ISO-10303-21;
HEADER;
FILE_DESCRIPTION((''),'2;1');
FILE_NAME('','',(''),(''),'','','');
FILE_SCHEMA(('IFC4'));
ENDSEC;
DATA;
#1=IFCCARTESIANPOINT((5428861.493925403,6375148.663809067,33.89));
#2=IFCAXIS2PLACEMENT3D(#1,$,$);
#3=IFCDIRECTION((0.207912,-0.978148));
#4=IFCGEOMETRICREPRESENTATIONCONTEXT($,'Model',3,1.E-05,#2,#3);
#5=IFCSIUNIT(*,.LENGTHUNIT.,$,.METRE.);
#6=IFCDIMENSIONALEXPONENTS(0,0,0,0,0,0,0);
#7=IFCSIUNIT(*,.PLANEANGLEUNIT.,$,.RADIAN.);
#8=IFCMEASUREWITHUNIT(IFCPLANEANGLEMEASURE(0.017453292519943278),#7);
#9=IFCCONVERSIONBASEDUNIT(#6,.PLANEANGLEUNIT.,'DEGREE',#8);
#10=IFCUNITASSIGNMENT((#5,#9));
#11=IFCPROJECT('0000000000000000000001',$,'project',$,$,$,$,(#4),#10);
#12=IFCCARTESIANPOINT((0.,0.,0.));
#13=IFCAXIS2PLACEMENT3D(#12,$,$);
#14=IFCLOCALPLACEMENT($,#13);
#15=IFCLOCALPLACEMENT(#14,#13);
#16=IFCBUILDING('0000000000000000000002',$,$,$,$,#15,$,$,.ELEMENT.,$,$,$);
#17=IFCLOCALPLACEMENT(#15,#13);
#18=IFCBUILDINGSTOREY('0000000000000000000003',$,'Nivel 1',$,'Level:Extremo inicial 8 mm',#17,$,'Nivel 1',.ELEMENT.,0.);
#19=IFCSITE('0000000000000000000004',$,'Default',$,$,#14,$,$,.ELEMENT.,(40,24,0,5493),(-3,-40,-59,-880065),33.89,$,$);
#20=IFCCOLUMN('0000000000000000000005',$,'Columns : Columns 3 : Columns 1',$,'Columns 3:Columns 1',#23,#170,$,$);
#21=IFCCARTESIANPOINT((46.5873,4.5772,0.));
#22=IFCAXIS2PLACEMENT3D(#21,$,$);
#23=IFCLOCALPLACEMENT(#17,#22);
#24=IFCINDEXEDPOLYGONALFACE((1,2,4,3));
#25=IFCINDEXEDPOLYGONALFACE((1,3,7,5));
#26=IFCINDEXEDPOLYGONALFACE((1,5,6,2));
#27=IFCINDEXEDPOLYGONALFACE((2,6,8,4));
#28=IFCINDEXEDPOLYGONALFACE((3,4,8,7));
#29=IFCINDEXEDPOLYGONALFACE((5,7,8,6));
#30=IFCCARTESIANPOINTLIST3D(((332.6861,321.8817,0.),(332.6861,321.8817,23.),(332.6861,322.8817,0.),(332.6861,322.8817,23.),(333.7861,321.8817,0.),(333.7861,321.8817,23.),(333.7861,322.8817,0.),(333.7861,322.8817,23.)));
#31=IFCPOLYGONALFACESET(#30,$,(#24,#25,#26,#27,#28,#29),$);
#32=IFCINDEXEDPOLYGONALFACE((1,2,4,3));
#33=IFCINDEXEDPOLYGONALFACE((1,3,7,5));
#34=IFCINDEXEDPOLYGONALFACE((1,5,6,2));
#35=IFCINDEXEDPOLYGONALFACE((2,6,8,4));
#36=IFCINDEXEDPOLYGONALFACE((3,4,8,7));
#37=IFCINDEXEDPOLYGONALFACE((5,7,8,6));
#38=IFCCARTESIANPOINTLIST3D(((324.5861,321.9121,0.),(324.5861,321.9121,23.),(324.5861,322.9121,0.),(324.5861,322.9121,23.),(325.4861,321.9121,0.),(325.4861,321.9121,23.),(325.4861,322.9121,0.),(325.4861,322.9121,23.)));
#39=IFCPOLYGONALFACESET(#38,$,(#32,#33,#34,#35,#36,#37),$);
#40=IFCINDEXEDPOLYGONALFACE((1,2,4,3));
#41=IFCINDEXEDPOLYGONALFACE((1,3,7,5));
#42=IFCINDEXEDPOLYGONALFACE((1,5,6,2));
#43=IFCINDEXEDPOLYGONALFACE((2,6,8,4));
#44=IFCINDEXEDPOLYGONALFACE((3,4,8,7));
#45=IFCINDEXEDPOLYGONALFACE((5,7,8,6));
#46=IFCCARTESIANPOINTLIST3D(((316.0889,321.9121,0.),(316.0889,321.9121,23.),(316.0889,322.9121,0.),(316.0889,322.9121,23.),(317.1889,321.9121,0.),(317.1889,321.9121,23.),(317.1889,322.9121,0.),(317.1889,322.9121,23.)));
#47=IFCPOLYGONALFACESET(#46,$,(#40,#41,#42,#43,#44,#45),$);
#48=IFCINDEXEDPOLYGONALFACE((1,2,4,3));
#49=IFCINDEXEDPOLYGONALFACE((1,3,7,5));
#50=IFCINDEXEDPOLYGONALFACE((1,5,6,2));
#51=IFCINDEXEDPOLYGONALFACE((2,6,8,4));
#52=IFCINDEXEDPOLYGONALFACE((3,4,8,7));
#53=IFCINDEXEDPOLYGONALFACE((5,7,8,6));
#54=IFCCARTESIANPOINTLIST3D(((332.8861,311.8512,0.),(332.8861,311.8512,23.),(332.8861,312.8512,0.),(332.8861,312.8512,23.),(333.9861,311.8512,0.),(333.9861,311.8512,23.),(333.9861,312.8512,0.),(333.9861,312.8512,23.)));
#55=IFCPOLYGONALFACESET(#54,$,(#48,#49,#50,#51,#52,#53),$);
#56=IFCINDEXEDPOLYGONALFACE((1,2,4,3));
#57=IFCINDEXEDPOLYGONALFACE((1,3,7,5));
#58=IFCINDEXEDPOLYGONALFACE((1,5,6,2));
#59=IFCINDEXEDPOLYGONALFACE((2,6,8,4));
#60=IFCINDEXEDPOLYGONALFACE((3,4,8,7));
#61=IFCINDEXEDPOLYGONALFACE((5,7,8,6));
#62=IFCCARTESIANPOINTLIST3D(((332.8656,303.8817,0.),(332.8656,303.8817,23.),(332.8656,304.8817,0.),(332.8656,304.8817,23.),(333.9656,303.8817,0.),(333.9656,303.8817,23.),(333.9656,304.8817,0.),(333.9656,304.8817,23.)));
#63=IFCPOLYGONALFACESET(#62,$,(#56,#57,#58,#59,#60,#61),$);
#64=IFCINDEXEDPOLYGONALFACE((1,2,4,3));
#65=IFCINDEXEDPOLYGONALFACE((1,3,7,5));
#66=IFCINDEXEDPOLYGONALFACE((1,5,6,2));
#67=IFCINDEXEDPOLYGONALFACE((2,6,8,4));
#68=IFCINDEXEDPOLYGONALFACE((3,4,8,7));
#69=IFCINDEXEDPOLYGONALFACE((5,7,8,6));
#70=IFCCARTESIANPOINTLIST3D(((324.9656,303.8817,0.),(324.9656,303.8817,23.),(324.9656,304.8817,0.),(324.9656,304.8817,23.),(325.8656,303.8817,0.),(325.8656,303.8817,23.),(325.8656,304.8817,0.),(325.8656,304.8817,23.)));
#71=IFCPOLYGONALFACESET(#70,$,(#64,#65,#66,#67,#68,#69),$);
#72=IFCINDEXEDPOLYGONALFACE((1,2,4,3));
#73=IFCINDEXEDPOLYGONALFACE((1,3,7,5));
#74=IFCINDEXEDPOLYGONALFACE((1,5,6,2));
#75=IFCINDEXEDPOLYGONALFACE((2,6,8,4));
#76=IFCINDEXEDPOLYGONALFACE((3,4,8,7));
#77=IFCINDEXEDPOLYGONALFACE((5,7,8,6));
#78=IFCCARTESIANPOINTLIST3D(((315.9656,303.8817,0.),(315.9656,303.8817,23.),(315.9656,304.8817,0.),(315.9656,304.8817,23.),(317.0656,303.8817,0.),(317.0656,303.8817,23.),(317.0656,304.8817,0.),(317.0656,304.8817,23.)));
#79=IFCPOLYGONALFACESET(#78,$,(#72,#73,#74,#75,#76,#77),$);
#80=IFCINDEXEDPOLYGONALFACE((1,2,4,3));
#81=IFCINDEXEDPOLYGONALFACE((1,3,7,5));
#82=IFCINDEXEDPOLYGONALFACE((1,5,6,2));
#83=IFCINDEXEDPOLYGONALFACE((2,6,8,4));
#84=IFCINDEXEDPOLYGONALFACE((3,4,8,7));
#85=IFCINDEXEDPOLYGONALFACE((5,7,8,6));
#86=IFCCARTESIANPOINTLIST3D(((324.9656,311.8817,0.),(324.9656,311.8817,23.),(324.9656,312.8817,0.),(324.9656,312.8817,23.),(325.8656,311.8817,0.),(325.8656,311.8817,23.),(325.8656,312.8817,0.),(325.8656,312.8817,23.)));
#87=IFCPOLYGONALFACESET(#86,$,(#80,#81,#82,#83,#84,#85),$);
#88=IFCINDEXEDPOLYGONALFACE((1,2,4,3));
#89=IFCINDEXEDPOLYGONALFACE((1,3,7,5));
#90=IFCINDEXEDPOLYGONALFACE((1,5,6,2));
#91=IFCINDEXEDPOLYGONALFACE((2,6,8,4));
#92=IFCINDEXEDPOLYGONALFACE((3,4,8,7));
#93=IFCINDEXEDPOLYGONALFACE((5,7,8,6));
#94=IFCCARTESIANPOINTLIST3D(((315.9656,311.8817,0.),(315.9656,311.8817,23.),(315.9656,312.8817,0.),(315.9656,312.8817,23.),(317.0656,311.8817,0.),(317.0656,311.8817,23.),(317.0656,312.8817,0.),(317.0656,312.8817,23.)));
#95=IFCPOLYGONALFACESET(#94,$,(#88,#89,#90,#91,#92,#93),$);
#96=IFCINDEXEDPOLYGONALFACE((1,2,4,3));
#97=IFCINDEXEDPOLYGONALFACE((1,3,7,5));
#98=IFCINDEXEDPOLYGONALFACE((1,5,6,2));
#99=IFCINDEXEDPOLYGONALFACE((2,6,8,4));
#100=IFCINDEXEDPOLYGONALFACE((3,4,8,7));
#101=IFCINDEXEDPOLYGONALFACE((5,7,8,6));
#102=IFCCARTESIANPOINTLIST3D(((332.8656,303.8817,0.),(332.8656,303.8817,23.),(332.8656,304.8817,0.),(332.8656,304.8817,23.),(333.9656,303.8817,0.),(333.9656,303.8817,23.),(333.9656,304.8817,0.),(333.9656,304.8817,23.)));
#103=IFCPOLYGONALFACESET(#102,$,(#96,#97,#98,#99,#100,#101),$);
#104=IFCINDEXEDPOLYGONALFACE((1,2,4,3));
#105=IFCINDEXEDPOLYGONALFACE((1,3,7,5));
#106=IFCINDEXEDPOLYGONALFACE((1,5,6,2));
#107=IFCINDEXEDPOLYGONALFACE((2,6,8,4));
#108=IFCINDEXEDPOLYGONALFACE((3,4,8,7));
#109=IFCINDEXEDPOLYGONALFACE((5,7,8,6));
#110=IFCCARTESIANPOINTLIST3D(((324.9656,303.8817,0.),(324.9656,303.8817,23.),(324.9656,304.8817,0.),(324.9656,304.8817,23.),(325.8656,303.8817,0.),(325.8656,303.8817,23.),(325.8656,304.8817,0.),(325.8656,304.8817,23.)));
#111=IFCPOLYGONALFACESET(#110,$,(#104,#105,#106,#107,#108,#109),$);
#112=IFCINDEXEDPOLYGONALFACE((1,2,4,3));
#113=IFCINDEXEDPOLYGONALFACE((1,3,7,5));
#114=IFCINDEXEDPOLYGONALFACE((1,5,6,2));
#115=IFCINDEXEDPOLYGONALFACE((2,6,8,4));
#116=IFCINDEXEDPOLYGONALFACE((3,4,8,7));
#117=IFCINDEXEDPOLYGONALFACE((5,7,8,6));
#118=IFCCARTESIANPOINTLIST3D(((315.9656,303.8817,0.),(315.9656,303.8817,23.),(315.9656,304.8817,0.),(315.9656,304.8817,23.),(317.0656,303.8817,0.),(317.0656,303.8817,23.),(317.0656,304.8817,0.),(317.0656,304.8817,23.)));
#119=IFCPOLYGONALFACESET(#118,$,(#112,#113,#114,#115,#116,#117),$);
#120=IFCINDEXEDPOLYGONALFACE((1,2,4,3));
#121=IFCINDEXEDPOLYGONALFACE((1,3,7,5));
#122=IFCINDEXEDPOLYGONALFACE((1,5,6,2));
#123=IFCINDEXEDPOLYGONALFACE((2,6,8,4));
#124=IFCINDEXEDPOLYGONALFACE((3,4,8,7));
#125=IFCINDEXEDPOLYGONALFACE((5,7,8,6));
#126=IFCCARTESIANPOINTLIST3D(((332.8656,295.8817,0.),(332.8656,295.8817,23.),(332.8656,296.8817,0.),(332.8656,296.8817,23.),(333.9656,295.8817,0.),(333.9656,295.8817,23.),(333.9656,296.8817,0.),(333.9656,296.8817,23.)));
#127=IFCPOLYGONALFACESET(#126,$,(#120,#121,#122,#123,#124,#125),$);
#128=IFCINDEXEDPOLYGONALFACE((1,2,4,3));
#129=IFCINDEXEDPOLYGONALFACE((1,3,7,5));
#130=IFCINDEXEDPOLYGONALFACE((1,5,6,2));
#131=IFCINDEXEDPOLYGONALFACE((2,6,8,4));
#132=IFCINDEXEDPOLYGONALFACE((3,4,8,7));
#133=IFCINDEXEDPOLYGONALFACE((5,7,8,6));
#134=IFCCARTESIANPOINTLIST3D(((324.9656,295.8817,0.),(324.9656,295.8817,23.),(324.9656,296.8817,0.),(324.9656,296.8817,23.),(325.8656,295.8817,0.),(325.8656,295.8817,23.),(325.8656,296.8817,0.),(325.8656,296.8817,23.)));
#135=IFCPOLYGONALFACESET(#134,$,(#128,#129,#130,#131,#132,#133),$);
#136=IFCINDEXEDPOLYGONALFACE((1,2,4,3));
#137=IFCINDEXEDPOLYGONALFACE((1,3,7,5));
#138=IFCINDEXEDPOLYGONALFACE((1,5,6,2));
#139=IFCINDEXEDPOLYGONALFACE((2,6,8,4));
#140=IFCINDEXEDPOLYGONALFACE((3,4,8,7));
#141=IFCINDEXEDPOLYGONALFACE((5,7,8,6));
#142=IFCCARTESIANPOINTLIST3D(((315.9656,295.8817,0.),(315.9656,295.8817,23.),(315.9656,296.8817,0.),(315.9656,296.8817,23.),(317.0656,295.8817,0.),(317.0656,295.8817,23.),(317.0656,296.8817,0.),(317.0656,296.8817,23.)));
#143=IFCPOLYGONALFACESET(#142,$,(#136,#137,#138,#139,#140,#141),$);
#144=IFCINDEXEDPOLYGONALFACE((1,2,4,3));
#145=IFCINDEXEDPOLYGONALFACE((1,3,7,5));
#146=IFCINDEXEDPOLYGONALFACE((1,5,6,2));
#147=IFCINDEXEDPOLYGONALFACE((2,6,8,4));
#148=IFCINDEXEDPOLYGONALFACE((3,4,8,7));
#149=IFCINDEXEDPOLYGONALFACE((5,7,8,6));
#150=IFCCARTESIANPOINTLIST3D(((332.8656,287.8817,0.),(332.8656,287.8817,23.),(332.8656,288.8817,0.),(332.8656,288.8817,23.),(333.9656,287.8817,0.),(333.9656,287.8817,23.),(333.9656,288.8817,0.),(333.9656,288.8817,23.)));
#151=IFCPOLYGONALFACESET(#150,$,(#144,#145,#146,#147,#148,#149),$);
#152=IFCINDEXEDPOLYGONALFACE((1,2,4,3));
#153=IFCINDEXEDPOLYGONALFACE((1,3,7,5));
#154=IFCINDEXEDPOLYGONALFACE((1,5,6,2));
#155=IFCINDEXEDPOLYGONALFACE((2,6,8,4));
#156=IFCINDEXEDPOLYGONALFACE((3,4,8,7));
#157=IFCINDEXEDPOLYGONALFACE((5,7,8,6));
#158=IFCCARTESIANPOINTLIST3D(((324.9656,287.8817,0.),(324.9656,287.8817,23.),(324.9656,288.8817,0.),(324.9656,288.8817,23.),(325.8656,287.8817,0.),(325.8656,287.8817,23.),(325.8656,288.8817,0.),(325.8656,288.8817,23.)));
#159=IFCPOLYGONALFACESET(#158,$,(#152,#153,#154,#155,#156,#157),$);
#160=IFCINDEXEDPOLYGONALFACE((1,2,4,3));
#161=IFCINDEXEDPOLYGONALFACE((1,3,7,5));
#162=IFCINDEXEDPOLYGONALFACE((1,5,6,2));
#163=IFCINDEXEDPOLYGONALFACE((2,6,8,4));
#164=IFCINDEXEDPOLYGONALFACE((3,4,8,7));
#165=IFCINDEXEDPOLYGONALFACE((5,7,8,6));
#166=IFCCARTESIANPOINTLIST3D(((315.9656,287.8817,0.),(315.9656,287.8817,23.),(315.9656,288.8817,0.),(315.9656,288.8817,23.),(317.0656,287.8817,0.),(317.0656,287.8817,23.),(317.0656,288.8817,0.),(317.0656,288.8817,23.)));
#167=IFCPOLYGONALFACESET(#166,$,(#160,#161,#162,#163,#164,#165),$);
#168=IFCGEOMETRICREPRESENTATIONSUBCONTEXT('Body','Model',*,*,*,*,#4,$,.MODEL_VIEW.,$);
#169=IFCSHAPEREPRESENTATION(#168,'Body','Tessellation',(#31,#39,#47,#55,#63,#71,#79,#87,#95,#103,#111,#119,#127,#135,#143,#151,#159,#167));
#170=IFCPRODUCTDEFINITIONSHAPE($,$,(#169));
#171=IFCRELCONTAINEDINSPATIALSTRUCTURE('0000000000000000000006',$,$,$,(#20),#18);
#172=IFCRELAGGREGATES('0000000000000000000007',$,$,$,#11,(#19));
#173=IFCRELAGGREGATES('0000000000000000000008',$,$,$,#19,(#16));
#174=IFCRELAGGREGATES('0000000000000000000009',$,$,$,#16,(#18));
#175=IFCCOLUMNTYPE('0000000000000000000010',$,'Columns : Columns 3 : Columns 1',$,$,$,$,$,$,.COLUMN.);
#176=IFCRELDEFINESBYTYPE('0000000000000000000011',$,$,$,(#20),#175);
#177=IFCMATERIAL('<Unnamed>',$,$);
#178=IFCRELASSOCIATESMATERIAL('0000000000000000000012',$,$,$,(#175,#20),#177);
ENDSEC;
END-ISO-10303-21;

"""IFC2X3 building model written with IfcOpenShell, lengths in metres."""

from ifc_helpers import new_model, entity, si_unit, converted_unit, direction, frame, frame_2d, origin, place, context, subcontext, project, spatial, rectangle, extrude, source, transform, mapped, material, type_object, type_shapes, element, save


model = new_model("IFC2X3")

# Units and contexts
model_context = context("Model", 3, precision=1e-05, world=frame((5428861.493925403, 6375148.663809067, 33.89)), true_north=direction((0.207912, -0.978148)))
body_context = subcontext(model_context, "Body", "Model", "MODEL_VIEW")
ifc_project = project(units=[si_unit("LENGTHUNIT", "METRE"), converted_unit("PLANEANGLEUNIT", "DEGREE", entity("IfcPlaneAngleMeasure", 0.017453292519943278), si_unit("PLANEANGLEUNIT", "RADIAN"), dimensions=[0, 0, 0, 0, 0, 0, 0])], contexts=[model_context])

# Site, building, storey
site_placement = place(None, origin())
site = spatial("IfcSite", under=ifc_project, at=site_placement, Name="Default", CompositionType="ELEMENT", RefLatitude=(40, 24, 0, 5493), RefLongitude=(-3, -40, -59, -880065), RefElevation=33.89)
building_placement = place(site_placement, origin())
building = spatial("IfcBuilding", under=site, at=building_placement, CompositionType="ELEMENT")
storey_placement = place(building_placement, origin())
storey = spatial("IfcBuildingStorey", under=building, at=storey_placement, Name="Nivel 1", ObjectType="Level:Extremo inicial 8 mm", LongName="Nivel 1", CompositionType="ELEMENT", Elevation=0.0)

# Column
ifc_material_1 = material(Name="<Unnamed>")
column_type = type_object("IfcColumnType", Name="Columns : Columns 3 : Columns 1", PredefinedType="COLUMN", material=ifc_material_1)
shared_shape = source(origin(), body_context, "Body", "SweptSolid", [
    extrude(rectangle(XDim=1.0, YDim=1.1, at=frame_2d((0.0, 0.0), x_axis=(1.0, 0.0))), frame((333.2361, 322.3817, 0.0), z_axis=(0.0, 0.0, 1.0), x_axis=(0.0, 1.0, 0.0)), (0.0, 0.0, 1.0), 23.0),
    extrude(rectangle(XDim=0.9, YDim=1.0, at=frame_2d((0.0, 0.0), x_axis=(1.0, 0.0))), frame((325.0361, 322.4121, 0.0)), (0.0, 0.0, 1.0), 23.0),
    extrude(rectangle(XDim=1.1, YDim=1.0, at=frame_2d((0.0, 0.0), x_axis=(1.0, 0.0))), frame((316.6389, 322.4121, 0.0)), (0.0, 0.0, 1.0), 23.0),
    extrude(rectangle(XDim=1.0, YDim=1.1, at=frame_2d((0.0, 0.0), x_axis=(1.0, 0.0))), frame((333.4361, 312.3512, 0.0), z_axis=(0.0, 0.0, 1.0), x_axis=(0.0, 1.0, 0.0)), (0.0, 0.0, 1.0), 23.0),
    extrude(rectangle(XDim=1.0, YDim=1.1, at=frame_2d((0.0, 0.0), x_axis=(1.0, 0.0))), frame((333.4156, 304.3817, 0.0), z_axis=(0.0, 0.0, 1.0), x_axis=(0.0, 1.0, 0.0)), (0.0, 0.0, 1.0), 23.0),
    extrude(rectangle(XDim=0.9, YDim=1.0, at=frame_2d((0.0, 0.0), x_axis=(1.0, 0.0))), frame((325.4156, 304.3817, 0.0)), (0.0, 0.0, 1.0), 23.0),
    extrude(rectangle(XDim=1.1, YDim=1.0, at=frame_2d((0.0, 0.0), x_axis=(1.0, 0.0))), frame((316.5156, 304.3817, 0.0)), (0.0, 0.0, 1.0), 23.0),
    extrude(rectangle(XDim=0.9, YDim=1.0, at=frame_2d((0.0, 0.0), x_axis=(1.0, 0.0))), frame((325.4156, 312.3817, 0.0)), (0.0, 0.0, 1.0), 23.0),
    extrude(rectangle(XDim=1.1, YDim=1.0, at=frame_2d((0.0, 0.0), x_axis=(1.0, 0.0))), frame((316.5156, 312.3817, 0.0)), (0.0, 0.0, 1.0), 23.0),
    extrude(rectangle(XDim=1.0, YDim=1.1, at=frame_2d((0.0, 0.0), x_axis=(1.0, 0.0))), frame((333.4156, 304.3817, 0.0), z_axis=(0.0, 0.0, 1.0), x_axis=(0.0, 1.0, 0.0)), (0.0, 0.0, 1.0), 23.0),
    extrude(rectangle(XDim=0.9, YDim=1.0, at=frame_2d((0.0, 0.0), x_axis=(1.0, 0.0))), frame((325.4156, 304.3817, 0.0)), (0.0, 0.0, 1.0), 23.0),
    extrude(rectangle(XDim=1.1, YDim=1.0, at=frame_2d((0.0, 0.0), x_axis=(1.0, 0.0))), frame((316.5156, 304.3817, 0.0)), (0.0, 0.0, 1.0), 23.0),
    extrude(rectangle(XDim=1.0, YDim=1.1, at=frame_2d((0.0, 0.0), x_axis=(1.0, 0.0))), frame((333.4156, 296.3817, 0.0), z_axis=(0.0, 0.0, 1.0), x_axis=(0.0, 1.0, 0.0)), (0.0, 0.0, 1.0), 23.0),
    extrude(rectangle(XDim=0.9, YDim=1.0, at=frame_2d((0.0, 0.0), x_axis=(1.0, 0.0))), frame((325.4156, 296.3817, 0.0)), (0.0, 0.0, 1.0), 23.0),
    extrude(rectangle(XDim=1.1, YDim=1.0, at=frame_2d((0.0, 0.0), x_axis=(1.0, 0.0))), frame((316.5156, 296.3817, 0.0)), (0.0, 0.0, 1.0), 23.0),
    extrude(rectangle(XDim=1.0, YDim=1.1, at=frame_2d((0.0, 0.0), x_axis=(1.0, 0.0))), frame((333.4156, 288.3817, 0.0), z_axis=(0.0, 0.0, 1.0), x_axis=(0.0, 1.0, 0.0)), (0.0, 0.0, 1.0), 23.0),
    extrude(rectangle(XDim=0.9, YDim=1.0, at=frame_2d((0.0, 0.0), x_axis=(1.0, 0.0))), frame((325.4156, 288.3817, 0.0)), (0.0, 0.0, 1.0), 23.0),
    extrude(rectangle(XDim=1.1, YDim=1.0, at=frame_2d((0.0, 0.0), x_axis=(1.0, 0.0))), frame((316.5156, 288.3817, 0.0)), (0.0, 0.0, 1.0), 23.0),
])
type_shapes(column_type, [shared_shape])
column_placement = place(storey_placement, frame((46.5873, 4.5772, 0.0)))
element("IfcColumn", 1, at=column_placement, inside=storey, type_object=column_type, material=ifc_material_1, Name="Columns : Columns 3 : Columns 1", ObjectType="Columns 3:Columns 1", context=body_context, shape_type="MappedRepresentation", body=[
    mapped(shared_shape, transform((0.0, 0.0, 0.0), scale=1.0)),
])

save(model, "model.ifc")
